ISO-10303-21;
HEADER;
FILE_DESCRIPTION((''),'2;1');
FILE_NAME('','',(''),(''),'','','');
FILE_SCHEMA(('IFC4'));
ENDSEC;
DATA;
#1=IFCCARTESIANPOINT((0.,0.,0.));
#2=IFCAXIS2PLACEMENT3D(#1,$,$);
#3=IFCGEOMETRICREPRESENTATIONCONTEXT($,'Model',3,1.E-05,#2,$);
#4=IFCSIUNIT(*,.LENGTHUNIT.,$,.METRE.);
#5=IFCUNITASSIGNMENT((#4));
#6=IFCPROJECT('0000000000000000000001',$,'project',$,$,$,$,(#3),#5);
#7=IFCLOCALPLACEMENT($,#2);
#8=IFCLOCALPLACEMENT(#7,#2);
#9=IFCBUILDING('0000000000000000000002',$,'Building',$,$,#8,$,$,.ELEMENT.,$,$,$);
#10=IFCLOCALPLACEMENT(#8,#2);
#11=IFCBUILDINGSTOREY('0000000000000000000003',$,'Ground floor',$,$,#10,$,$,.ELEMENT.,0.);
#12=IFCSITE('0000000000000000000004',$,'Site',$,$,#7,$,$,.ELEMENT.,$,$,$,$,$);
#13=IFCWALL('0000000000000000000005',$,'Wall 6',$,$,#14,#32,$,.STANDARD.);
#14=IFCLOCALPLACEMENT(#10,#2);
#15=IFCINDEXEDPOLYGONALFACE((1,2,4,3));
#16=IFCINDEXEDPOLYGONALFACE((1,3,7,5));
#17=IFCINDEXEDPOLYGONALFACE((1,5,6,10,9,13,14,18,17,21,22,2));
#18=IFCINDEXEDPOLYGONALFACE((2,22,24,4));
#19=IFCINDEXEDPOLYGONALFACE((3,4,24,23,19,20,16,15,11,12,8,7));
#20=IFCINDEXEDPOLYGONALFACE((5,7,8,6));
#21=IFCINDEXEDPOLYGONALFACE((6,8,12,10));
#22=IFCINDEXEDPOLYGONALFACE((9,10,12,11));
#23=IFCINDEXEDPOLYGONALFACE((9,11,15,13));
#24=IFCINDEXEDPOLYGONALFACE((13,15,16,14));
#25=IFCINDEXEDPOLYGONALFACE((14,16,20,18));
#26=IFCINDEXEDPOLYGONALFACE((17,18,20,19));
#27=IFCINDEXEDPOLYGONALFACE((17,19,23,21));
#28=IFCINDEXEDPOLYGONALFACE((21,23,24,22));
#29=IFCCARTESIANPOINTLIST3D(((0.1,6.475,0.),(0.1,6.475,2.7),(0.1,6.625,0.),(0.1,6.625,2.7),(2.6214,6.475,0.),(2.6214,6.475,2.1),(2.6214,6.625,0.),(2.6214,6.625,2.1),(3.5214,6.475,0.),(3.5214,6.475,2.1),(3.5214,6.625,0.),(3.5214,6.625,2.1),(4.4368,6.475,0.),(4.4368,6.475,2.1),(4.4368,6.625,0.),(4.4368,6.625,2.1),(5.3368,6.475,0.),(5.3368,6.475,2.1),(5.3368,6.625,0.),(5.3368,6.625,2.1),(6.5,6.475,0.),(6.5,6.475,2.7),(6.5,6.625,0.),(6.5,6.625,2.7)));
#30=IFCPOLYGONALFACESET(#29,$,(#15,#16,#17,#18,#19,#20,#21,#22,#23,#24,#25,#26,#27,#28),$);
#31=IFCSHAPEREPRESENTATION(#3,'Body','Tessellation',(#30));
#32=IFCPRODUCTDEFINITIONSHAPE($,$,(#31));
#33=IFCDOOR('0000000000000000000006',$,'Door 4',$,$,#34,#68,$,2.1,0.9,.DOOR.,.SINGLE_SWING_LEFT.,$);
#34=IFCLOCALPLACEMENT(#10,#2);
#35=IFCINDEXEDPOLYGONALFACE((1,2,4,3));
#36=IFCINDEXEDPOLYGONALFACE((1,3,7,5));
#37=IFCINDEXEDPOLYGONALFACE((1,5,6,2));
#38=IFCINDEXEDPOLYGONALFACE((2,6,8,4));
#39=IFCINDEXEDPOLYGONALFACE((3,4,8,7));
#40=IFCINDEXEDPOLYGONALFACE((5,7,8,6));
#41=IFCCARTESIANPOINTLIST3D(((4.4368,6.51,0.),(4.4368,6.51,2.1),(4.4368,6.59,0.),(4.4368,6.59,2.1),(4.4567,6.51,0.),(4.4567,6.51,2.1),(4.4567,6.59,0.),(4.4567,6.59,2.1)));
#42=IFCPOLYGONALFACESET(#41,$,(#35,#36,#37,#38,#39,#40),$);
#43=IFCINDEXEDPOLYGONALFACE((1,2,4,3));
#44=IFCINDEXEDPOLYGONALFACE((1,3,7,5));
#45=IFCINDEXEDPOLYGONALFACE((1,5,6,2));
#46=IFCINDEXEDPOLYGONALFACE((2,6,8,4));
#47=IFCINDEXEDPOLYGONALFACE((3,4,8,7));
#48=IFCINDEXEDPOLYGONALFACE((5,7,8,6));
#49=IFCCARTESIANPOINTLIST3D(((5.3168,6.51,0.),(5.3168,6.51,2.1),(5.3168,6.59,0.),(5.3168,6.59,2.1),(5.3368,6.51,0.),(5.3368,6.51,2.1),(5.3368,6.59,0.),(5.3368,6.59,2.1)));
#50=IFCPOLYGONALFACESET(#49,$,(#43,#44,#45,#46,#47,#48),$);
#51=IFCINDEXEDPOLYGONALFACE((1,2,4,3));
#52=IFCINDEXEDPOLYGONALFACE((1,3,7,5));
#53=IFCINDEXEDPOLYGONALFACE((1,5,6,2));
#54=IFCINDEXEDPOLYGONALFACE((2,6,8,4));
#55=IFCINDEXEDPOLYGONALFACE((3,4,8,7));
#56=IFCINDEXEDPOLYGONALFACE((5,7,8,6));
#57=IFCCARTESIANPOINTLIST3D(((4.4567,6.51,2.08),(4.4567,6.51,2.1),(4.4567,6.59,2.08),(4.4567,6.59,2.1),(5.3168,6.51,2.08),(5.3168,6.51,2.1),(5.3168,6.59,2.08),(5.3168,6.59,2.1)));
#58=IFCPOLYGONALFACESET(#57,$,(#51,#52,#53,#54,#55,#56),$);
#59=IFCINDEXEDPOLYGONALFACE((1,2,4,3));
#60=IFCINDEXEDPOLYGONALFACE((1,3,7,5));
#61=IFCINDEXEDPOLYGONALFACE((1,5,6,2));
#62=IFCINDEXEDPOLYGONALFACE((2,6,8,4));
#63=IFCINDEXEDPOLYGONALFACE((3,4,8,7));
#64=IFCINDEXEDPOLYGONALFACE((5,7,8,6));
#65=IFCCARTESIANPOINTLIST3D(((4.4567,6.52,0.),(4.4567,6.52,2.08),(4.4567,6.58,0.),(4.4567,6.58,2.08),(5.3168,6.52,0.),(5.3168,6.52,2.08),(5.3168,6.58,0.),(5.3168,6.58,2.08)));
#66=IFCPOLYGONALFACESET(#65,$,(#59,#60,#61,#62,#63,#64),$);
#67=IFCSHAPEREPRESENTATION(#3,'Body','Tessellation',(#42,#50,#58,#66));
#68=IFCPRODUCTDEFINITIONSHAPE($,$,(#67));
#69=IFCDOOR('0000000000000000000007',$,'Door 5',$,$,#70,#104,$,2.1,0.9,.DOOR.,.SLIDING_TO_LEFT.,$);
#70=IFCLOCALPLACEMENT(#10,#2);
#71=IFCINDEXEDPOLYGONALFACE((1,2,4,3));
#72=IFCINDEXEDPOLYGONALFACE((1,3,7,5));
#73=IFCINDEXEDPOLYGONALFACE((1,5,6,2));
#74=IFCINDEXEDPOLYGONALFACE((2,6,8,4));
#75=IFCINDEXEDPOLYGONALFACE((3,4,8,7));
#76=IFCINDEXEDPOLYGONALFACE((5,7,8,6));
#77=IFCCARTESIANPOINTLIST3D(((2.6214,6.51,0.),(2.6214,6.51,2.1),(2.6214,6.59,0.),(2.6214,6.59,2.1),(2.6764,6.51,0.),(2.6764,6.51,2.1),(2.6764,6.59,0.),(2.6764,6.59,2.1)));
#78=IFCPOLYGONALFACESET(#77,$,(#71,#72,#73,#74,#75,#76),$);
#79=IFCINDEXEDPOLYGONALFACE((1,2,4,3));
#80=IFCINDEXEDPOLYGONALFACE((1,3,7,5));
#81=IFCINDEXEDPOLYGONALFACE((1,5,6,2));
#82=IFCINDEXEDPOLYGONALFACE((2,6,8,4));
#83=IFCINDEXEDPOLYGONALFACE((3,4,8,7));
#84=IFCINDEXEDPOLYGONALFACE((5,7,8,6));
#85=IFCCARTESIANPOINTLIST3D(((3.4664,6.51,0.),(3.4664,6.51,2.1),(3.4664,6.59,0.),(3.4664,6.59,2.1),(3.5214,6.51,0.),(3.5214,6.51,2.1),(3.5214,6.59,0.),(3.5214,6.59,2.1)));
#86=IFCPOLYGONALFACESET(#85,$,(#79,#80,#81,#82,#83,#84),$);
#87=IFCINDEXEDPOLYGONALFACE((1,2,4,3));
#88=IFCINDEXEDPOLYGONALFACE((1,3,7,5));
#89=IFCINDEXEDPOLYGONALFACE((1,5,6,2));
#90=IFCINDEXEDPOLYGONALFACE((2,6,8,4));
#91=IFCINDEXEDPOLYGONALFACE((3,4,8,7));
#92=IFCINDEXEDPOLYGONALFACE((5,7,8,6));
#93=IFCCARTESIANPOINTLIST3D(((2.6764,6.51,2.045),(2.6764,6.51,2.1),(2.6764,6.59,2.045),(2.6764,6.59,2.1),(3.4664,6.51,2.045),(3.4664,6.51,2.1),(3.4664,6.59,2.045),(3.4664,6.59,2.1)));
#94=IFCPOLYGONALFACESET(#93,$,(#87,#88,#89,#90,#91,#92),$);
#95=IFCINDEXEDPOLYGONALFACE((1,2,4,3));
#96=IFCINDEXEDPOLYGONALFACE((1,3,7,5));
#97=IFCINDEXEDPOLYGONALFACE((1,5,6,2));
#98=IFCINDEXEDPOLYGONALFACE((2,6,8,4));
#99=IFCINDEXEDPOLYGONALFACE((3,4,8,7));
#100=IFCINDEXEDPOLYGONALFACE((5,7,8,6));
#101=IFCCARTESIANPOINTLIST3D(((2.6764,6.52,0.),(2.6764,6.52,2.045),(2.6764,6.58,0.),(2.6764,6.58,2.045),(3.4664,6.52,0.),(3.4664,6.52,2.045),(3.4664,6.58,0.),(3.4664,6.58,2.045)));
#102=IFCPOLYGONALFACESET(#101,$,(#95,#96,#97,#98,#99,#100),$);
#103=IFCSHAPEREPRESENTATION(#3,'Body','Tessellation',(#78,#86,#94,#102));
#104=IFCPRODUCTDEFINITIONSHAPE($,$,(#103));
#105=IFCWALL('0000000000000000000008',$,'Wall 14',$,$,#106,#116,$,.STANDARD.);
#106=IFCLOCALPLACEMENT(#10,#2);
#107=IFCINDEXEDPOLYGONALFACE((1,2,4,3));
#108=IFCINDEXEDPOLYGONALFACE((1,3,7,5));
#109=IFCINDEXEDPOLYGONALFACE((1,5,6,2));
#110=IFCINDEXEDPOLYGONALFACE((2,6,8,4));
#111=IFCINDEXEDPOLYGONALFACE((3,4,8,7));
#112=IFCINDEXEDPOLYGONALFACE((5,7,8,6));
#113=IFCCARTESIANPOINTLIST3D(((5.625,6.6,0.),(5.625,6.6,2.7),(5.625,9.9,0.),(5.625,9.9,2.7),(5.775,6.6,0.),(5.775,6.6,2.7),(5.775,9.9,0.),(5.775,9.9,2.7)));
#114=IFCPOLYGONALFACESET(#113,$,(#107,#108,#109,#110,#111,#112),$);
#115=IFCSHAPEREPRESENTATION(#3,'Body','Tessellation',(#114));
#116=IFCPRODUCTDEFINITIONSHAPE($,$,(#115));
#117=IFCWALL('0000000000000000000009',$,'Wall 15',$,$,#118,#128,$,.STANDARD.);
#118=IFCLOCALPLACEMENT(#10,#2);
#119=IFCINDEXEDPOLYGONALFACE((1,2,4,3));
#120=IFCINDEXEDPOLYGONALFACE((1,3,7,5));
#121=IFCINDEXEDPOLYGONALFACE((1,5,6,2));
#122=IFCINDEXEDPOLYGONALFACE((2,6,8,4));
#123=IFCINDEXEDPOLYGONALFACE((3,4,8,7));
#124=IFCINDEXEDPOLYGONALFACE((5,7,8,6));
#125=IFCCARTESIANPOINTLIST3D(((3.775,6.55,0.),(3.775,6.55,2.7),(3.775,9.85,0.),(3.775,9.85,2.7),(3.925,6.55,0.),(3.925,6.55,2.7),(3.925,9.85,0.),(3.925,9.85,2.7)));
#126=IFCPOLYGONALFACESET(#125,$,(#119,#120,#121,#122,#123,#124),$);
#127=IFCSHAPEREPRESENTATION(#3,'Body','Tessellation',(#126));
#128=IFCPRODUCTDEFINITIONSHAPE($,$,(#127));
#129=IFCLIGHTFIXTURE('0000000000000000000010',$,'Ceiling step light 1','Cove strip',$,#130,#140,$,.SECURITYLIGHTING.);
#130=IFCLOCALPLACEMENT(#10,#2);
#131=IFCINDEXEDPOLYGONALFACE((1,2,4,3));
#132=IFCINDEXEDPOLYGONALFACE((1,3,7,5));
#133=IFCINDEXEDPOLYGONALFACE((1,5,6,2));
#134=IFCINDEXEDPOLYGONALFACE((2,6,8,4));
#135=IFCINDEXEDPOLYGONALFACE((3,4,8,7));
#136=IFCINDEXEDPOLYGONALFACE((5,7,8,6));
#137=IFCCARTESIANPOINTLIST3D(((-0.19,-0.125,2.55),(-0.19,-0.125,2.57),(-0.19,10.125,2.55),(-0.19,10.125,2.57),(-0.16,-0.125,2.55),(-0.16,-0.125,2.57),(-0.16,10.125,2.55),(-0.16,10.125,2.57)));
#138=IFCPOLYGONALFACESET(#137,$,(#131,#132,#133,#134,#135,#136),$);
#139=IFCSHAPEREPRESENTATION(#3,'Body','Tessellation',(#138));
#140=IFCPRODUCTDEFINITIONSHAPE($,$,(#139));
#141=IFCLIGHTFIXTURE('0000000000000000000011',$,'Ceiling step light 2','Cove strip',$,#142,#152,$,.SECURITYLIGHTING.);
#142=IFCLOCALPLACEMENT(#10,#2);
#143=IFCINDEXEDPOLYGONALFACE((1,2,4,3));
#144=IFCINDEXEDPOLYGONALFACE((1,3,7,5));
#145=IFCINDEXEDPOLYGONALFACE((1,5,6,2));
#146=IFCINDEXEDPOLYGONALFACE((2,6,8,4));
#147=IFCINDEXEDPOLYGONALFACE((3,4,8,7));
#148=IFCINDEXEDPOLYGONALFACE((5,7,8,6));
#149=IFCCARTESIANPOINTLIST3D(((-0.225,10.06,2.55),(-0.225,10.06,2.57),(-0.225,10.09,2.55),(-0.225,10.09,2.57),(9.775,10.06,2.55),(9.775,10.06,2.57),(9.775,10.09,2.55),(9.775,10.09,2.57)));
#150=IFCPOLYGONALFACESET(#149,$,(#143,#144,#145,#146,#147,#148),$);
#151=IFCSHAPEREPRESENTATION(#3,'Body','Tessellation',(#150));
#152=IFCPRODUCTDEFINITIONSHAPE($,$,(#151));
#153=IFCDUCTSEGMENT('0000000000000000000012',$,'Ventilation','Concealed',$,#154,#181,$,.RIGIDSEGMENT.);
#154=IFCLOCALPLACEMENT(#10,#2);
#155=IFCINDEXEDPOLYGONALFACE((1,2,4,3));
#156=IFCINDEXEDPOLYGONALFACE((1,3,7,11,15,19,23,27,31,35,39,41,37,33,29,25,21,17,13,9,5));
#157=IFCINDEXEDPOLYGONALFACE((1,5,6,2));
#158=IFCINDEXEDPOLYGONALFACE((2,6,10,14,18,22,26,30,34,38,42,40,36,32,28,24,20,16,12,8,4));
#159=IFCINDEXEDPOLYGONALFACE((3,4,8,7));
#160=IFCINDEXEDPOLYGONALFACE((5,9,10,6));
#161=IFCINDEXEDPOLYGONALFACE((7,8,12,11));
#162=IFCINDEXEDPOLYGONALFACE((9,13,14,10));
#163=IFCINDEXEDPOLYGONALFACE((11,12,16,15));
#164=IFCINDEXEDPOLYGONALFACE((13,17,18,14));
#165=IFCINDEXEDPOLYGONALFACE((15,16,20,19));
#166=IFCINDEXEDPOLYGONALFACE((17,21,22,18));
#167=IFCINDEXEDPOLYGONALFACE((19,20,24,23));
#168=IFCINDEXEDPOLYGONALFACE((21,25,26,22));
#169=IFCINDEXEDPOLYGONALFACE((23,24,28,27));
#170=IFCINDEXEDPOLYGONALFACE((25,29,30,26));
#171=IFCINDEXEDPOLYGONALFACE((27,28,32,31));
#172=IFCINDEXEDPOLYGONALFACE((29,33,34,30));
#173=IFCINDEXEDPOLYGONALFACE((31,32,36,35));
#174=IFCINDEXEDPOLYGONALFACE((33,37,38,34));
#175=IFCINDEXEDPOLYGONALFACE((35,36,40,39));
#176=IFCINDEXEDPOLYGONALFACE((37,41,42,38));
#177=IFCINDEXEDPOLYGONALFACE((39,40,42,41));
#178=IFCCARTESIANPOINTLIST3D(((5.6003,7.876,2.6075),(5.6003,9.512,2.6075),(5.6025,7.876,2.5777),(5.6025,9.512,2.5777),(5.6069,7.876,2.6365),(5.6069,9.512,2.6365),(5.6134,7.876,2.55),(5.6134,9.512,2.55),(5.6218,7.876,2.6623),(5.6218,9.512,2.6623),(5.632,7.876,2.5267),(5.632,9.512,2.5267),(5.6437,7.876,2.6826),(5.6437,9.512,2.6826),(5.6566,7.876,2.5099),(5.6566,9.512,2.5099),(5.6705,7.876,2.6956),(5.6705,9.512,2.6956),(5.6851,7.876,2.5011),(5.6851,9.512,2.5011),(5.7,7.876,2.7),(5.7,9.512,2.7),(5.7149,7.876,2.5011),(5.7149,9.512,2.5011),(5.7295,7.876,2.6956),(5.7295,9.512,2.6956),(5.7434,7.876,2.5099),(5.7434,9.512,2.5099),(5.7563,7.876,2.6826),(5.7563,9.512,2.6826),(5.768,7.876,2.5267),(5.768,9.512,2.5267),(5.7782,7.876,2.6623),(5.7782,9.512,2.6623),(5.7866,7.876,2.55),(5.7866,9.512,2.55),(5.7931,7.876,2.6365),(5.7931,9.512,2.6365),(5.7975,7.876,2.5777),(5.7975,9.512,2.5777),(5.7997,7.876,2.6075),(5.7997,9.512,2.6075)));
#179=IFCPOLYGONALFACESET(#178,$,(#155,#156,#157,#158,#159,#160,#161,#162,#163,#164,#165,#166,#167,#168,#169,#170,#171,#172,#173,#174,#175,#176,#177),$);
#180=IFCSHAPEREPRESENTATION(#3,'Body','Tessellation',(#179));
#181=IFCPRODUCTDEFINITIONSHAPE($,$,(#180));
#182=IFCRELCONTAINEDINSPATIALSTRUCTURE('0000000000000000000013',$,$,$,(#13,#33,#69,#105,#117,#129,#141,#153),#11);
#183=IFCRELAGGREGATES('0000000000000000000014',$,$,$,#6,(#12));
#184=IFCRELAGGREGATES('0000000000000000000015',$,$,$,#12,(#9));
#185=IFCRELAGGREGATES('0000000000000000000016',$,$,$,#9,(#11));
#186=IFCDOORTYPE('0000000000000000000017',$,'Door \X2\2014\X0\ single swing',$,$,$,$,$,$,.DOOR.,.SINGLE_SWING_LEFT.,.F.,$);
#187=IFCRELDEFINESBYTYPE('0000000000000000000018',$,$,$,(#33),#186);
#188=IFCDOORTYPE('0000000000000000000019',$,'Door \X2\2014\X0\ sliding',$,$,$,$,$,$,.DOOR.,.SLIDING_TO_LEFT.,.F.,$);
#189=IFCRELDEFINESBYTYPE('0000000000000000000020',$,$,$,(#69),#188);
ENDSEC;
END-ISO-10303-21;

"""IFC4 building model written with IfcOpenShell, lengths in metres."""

from ifc_helpers import new_model, si_unit, frame, frame_2d, origin, origin_2d, place, context, project, spatial, rectangle, circle, extrude, type_object, element, fill, save


model = new_model("IFC4")

# Units and contexts
model_context = context("Model", 3, precision=1e-05, world=origin())
ifc_project = project(units=[si_unit("LENGTHUNIT", "METRE")], contexts=[model_context])

# Site, building, storey
site_placement = place(None, origin())
site = spatial("IfcSite", under=ifc_project, at=site_placement, Name="Site", CompositionType="ELEMENT")
building_placement = place(site_placement, origin())
building = spatial("IfcBuilding", under=site, at=building_placement, Name="Building", CompositionType="ELEMENT")
storey_placement = place(building_placement, origin())
storey = spatial("IfcBuildingStorey", under=building, at=storey_placement, Name="Ground floor", CompositionType="ELEMENT", Elevation=0.0)

# Wall, openings, doors
wall_placement = place(storey_placement, frame((0.1, 6.55, 0.0), z_axis=(0.0, 0.0, 1.0), x_axis=(1.0, 0.0, 0.0)))
wall = element("IfcWall", 1, at=wall_placement, inside=storey, Name="Wall 6", PredefinedType="STANDARD", context=model_context, shape_type="SweptSolid", body=[
    extrude(rectangle(XDim=6.4, YDim=0.15, at=frame_2d((3.2, 0.0))), origin(), (0.0, 0.0, 1.0), 2.7),
])
opening_1_placement = place(storey_placement, frame((4.4367, 6.55, 0.0), z_axis=(0.0, 0.0, 1.0), x_axis=(1.0, 0.0, 0.0)))
opening_1 = element("IfcOpeningElement", 2, at=opening_1_placement, cuts=wall, PredefinedType="OPENING", context=model_context, shape_type="SweptSolid", body=[
    extrude(rectangle(XDim=0.9, YDim=0.21, at=frame_2d((0.45, 0.0))), origin(), (0.0, 0.0, 1.0), 2.1),
])
opening_2_placement = place(storey_placement, frame((2.6214, 6.55, 0.0), z_axis=(0.0, 0.0, 1.0), x_axis=(1.0, 0.0, 0.0)))
opening_2 = element("IfcOpeningElement", 3, at=opening_2_placement, cuts=wall, PredefinedType="OPENING", context=model_context, shape_type="SweptSolid", body=[
    extrude(rectangle(XDim=0.9, YDim=0.21, at=frame_2d((0.45, 0.0))), origin(), (0.0, 0.0, 1.0), 2.1),
])
door_type_1 = type_object("IfcDoorType", Name="Door — single swing", OperationType="SINGLE_SWING_LEFT", ParameterTakesPrecedence=False, PredefinedType="DOOR")
door_1_placement = place(storey_placement, frame((4.4367, 6.55, 0.0), z_axis=(0.0, 0.0, 1.0), x_axis=(1.0, 0.0, 0.0)))
door_1 = element("IfcDoor", 4, at=door_1_placement, inside=storey, type_object=door_type_1, Name="Door 4", OperationType="SINGLE_SWING_LEFT", OverallHeight=2.1, OverallWidth=0.9, PredefinedType="DOOR", context=model_context, shape_type="SweptSolid", body=[
    extrude(rectangle(XDim=0.02, YDim=0.08, at=frame_2d((0.01, 0.0))), origin(), (0.0, 0.0, 1.0), 2.1),
    extrude(rectangle(XDim=0.02, YDim=0.08, at=frame_2d((0.89, 0.0))), origin(), (0.0, 0.0, 1.0), 2.1),
    extrude(rectangle(XDim=0.86, YDim=0.08, at=frame_2d((0.45, 0.0))), frame((0.0, 0.0, 2.08)), (0.0, 0.0, 1.0), 0.02),
    extrude(rectangle(XDim=0.86, YDim=0.06, at=frame_2d((0.45, 0.0))), origin(), (0.0, 0.0, 1.0), 2.08),
])
fill(opening_1, door_1)
door_type_2 = type_object("IfcDoorType", Name="Door — sliding", OperationType="SLIDING_TO_LEFT", ParameterTakesPrecedence=False, PredefinedType="DOOR")
door_2_placement = place(storey_placement, frame((2.6214, 6.55, 0.0), z_axis=(0.0, 0.0, 1.0), x_axis=(1.0, 0.0, 0.0)))
door_2 = element("IfcDoor", 5, at=door_2_placement, inside=storey, type_object=door_type_2, Name="Door 5", OperationType="SLIDING_TO_LEFT", OverallHeight=2.1, OverallWidth=0.9, PredefinedType="DOOR", context=model_context, shape_type="SweptSolid", body=[
    extrude(rectangle(XDim=0.055, YDim=0.08, at=frame_2d((0.0275, 0.0))), origin(), (0.0, 0.0, 1.0), 2.1),
    extrude(rectangle(XDim=0.055, YDim=0.08, at=frame_2d((0.8725, 0.0))), origin(), (0.0, 0.0, 1.0), 2.1),
    extrude(rectangle(XDim=0.79, YDim=0.08, at=frame_2d((0.45, 0.0))), frame((0.0, 0.0, 2.045)), (0.0, 0.0, 1.0), 0.055),
    extrude(rectangle(XDim=0.79, YDim=0.06, at=frame_2d((0.45, 0.0))), origin(), (0.0, 0.0, 1.0), 2.045),
])
fill(opening_2, door_2)

# Walls
for number, where, z_axis, x_axis, name in (
    (6, (5.7, 9.9, 0.0), (0.0, 0.0, 1.0), (0.0, -1.0, 0.0), "Wall 14"),
    (7, (3.85, 9.85, 0.0), (0.0, 0.0, 1.0), (0.0, -1.0, 0.0), "Wall 15"),
):
    element("IfcWall", number, at=place(storey_placement, frame(where, z_axis=z_axis, x_axis=x_axis)), inside=storey, Name=name, PredefinedType="STANDARD", context=model_context, shape_type="SweptSolid", body=[
        extrude(rectangle(XDim=3.3, YDim=0.15, at=frame_2d((1.65, 0.0))), origin(), (0.0, 0.0, 1.0), 2.7),
    ])

# Light fixtures
light_fixture_1_placement = place(storey_placement, frame((-0.175, 5.0, 2.55), z_axis=(0.0, 0.0, 1.0), x_axis=(0.0, 1.0, 0.0)))
element("IfcLightFixture", 8, at=light_fixture_1_placement, inside=storey, Name="Ceiling step light 1", Description="Cove strip", PredefinedType="SECURITYLIGHTING", context=model_context, shape_type="SweptSolid", body=[
    extrude(rectangle(XDim=10.25, YDim=0.03, at=origin_2d()), origin(), (0.0, 0.0, 1.0), 0.02),
])
light_fixture_2_placement = place(storey_placement, frame((4.775, 10.075, 2.55), z_axis=(0.0, 0.0, 1.0), x_axis=(1.0, 0.0, 0.0)))
element("IfcLightFixture", 9, at=light_fixture_2_placement, inside=storey, Name="Ceiling step light 2", Description="Cove strip", PredefinedType="SECURITYLIGHTING", context=model_context, shape_type="SweptSolid", body=[
    extrude(rectangle(XDim=10.0, YDim=0.03, at=origin_2d()), origin(), (0.0, 0.0, 1.0), 0.02),
])

# Duct segment
duct_segment_placement = place(storey_placement, frame((5.7, 9.512, 2.6), z_axis=(0.0, -1.0, 0.0), x_axis=(0.0, 0.0, 1.0)))
element("IfcDuctSegment", 10, at=duct_segment_placement, inside=storey, Name="Ventilation", Description="Concealed", PredefinedType="RIGIDSEGMENT", context=model_context, shape_type="SweptSolid", body=[
    extrude(circle(Radius=0.1, at=origin_2d()), origin(), (0.0, 0.0, 1.0), 1.636),
])

save(model, "model.ifc")
